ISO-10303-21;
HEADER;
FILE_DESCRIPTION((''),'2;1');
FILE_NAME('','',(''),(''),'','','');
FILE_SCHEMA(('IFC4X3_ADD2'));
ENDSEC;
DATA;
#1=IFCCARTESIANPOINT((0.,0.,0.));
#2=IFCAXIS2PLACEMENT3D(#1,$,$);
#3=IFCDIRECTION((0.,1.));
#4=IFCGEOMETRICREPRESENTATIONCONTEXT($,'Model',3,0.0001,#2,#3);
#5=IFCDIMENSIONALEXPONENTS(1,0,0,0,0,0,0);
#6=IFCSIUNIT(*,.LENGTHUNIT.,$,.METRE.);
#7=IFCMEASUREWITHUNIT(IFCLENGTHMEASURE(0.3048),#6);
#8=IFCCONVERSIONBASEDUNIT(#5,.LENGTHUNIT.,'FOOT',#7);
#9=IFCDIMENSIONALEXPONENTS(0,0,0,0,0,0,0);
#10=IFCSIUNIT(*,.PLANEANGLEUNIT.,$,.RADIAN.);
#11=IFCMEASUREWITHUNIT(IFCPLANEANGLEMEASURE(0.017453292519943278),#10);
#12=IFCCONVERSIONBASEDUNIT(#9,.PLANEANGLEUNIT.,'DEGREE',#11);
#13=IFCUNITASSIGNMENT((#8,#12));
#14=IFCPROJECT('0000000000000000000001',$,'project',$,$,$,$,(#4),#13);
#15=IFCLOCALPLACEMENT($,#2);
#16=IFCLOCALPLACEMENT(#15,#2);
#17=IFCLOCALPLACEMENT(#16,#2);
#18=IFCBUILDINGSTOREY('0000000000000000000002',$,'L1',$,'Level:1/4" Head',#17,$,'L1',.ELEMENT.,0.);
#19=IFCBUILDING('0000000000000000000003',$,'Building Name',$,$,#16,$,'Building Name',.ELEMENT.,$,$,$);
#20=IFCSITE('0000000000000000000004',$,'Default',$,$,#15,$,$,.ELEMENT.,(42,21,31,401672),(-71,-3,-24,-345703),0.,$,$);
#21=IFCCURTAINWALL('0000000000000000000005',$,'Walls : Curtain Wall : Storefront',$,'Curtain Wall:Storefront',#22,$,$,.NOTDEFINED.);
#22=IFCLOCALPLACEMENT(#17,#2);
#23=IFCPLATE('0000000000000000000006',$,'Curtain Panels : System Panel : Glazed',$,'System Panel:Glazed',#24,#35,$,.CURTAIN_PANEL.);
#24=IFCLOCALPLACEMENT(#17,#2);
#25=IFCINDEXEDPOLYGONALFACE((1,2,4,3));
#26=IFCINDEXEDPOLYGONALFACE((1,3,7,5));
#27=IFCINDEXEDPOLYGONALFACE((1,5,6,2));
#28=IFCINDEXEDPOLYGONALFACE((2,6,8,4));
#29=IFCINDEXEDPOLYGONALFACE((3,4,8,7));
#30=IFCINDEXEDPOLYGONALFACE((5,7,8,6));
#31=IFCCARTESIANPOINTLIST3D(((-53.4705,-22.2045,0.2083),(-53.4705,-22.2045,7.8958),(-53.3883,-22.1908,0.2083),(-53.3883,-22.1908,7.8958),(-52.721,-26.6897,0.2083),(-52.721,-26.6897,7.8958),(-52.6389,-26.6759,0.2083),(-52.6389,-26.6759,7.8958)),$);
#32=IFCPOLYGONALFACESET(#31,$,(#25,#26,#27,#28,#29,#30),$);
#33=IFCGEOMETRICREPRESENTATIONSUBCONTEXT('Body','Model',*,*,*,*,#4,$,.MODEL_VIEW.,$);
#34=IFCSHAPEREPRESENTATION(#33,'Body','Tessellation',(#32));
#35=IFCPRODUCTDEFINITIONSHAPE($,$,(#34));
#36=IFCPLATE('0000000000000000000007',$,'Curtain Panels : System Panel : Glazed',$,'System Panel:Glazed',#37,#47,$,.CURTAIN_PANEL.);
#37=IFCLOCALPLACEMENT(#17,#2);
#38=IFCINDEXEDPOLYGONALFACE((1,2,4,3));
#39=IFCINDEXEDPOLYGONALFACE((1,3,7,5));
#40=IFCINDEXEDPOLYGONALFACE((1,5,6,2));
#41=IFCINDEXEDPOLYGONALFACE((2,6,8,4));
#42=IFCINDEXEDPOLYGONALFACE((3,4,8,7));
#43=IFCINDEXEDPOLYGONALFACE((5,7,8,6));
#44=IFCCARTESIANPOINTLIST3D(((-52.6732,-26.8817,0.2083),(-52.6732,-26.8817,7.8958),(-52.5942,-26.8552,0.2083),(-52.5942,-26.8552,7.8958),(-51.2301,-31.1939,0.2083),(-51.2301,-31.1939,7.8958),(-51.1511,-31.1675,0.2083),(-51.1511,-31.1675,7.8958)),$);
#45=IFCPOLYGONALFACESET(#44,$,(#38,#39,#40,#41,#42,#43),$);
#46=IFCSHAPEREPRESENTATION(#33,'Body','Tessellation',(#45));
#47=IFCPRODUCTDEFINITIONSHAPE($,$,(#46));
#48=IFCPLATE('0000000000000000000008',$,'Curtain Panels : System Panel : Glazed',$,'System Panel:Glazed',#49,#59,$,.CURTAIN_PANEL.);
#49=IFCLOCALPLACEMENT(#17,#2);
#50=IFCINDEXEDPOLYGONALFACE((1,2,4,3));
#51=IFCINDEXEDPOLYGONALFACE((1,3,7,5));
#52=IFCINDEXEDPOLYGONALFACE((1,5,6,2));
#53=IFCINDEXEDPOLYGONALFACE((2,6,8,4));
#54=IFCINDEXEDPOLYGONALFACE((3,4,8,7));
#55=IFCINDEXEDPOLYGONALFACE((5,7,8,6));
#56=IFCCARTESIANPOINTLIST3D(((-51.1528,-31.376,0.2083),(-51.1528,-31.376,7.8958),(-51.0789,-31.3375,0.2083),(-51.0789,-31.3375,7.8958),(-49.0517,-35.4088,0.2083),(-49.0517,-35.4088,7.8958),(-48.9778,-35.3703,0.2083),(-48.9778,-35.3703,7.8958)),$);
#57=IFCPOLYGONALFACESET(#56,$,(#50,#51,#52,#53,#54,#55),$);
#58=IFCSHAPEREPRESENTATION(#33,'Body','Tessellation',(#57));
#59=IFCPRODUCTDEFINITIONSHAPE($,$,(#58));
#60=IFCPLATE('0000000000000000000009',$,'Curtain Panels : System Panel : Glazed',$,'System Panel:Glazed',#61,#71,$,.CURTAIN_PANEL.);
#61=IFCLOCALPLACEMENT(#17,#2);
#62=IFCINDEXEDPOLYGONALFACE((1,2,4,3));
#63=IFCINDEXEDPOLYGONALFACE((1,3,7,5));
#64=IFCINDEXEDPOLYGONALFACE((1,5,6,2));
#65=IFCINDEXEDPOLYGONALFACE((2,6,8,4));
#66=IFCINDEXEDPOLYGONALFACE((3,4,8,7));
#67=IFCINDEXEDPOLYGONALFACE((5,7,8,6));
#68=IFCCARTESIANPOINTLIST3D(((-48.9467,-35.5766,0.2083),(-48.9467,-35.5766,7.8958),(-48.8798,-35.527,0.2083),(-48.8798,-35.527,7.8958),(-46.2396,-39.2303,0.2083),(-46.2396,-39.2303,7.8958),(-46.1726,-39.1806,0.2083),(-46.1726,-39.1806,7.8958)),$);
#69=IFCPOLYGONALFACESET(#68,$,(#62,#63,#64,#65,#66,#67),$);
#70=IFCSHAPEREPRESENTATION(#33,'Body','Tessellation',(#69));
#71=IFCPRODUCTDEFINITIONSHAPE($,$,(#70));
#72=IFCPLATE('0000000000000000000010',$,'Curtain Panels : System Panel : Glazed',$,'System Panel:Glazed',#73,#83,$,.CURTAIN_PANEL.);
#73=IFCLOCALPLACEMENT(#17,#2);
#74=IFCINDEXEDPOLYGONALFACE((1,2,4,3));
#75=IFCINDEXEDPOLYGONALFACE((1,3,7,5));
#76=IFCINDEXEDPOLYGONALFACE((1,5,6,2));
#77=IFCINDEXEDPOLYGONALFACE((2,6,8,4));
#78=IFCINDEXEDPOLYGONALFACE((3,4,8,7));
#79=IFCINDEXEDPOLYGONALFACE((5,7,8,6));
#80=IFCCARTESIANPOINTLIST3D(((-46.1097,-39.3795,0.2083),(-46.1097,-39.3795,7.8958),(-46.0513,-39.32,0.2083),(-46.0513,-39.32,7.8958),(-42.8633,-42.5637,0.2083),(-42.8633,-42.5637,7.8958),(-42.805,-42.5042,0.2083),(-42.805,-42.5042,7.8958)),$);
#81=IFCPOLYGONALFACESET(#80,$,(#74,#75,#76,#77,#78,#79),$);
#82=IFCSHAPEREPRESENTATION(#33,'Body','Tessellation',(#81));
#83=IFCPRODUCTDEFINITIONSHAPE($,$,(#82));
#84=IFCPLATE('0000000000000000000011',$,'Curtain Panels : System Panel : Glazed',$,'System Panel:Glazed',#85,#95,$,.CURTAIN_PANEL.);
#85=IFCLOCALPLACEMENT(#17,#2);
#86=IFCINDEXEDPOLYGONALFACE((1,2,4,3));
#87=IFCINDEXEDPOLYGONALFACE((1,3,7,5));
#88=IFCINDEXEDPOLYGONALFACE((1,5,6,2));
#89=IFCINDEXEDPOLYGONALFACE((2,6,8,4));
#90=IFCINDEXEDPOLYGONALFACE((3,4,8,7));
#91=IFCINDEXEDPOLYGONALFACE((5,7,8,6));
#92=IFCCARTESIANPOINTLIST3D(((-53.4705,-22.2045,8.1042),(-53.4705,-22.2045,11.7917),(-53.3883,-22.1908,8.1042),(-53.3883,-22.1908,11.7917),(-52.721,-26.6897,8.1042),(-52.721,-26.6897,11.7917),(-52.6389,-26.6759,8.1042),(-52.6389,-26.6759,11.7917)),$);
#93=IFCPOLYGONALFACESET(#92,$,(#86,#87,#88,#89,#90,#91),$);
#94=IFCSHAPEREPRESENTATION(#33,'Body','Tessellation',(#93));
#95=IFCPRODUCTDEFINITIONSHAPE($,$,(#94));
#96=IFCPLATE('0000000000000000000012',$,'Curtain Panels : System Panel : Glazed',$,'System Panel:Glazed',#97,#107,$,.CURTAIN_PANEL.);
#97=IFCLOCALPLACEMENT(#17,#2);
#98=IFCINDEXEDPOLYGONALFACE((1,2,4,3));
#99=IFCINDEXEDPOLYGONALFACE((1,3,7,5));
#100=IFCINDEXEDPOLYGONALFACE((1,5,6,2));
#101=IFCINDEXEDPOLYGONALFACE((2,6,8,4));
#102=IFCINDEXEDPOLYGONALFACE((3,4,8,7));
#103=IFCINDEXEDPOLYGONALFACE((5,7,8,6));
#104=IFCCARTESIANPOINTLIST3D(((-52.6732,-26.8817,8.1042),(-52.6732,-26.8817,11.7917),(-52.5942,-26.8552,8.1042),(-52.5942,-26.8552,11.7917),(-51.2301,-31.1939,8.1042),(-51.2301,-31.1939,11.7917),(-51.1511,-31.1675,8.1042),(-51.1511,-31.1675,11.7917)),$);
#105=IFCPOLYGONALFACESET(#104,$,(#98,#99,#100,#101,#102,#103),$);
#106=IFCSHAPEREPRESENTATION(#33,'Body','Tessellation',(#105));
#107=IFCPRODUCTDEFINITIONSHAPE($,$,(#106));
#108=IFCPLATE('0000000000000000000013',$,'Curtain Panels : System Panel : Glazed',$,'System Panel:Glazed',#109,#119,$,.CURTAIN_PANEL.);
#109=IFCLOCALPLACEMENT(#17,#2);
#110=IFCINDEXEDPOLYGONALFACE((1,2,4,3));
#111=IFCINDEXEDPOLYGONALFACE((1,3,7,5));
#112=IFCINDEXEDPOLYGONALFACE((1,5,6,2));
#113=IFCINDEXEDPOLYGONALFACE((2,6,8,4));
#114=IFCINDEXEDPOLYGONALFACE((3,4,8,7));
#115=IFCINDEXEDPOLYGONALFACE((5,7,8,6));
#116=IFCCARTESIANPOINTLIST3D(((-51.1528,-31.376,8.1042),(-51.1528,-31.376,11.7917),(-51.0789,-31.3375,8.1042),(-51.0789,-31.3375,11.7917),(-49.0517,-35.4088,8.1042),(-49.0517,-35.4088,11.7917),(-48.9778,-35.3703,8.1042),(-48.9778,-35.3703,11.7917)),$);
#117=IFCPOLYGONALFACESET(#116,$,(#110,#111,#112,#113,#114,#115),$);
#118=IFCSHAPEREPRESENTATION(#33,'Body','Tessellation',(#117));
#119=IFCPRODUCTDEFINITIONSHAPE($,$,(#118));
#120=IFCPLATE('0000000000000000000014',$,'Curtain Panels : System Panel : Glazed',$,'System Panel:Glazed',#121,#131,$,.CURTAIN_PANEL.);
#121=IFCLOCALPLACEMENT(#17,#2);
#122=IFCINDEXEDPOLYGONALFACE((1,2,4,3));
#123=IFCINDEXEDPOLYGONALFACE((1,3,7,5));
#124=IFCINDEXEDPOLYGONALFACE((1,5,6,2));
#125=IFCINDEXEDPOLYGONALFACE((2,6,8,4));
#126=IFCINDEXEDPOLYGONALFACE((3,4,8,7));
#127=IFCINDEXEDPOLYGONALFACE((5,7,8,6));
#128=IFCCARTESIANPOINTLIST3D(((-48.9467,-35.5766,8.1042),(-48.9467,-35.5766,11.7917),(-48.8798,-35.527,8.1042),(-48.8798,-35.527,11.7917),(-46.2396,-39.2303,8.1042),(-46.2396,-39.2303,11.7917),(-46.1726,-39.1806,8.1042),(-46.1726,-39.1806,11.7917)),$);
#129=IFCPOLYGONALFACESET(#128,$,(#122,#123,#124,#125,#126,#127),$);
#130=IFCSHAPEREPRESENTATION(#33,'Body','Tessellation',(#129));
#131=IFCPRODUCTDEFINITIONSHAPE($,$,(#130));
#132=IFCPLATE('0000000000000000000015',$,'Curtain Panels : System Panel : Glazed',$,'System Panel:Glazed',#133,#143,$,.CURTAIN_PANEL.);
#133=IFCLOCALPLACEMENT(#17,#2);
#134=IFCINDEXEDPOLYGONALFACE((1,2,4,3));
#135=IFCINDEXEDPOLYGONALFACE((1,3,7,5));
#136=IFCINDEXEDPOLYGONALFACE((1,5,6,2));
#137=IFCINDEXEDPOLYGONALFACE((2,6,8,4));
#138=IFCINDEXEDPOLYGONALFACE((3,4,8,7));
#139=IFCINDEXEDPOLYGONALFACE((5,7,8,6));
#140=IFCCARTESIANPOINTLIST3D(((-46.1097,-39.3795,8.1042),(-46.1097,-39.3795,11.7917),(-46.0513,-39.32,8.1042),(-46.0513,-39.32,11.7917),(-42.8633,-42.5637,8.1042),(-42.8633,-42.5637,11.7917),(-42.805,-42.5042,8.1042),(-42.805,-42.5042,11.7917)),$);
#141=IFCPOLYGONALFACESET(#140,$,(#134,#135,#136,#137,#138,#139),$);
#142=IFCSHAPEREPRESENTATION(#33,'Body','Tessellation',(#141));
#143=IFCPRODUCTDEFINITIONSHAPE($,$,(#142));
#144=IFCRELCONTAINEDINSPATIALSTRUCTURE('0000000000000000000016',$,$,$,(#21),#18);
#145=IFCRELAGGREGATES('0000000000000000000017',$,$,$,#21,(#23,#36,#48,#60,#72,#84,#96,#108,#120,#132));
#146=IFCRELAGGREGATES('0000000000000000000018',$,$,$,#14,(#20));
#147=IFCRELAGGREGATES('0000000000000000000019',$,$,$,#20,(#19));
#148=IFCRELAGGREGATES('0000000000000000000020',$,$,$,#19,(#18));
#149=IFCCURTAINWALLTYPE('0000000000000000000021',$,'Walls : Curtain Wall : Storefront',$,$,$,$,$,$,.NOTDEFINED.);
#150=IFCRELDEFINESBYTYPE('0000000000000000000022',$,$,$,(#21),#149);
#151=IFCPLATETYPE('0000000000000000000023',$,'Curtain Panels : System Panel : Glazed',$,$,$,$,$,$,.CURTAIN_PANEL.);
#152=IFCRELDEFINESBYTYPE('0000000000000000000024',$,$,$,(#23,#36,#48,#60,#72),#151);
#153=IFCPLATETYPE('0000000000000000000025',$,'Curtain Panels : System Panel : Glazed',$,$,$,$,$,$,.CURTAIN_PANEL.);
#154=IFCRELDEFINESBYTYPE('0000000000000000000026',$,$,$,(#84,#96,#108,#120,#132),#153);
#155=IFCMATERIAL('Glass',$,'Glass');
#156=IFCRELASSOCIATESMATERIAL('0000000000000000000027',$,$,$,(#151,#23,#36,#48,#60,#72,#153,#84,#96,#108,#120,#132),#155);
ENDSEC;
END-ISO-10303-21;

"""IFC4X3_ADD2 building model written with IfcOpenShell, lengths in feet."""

from ifc_helpers import new_model, entity, si_unit, converted_unit, direction, frame, frame_2d, origin, place, context, subcontext, project, spatial, rectangle, extrude, source, transform, mapped, material, type_object, type_shapes, element, aggregate, save


model = new_model("IFC4X3_ADD2")

# Units and contexts
model_context = context("Model", 3, precision=0.0001, world=origin(), true_north=direction((0.0, 1.0)))
body_context = subcontext(model_context, "Body", "Model", "MODEL_VIEW")
ifc_project = project(units=[converted_unit("LENGTHUNIT", "FOOT", entity("IfcLengthMeasure", 0.3048), si_unit("LENGTHUNIT", "METRE"), dimensions=[1, 0, 0, 0, 0, 0, 0]), converted_unit("PLANEANGLEUNIT", "DEGREE", entity("IfcPlaneAngleMeasure", 0.017453292519943278), si_unit("PLANEANGLEUNIT", "RADIAN"), dimensions=[0, 0, 0, 0, 0, 0, 0])], contexts=[model_context])

# Site, building, storey
site_placement = place(None, origin())
site = spatial("IfcSite", under=ifc_project, at=site_placement, Name="Default", CompositionType="ELEMENT", RefLatitude=(42, 21, 31, 401672), RefLongitude=(-71, -3, -24, -345703), RefElevation=0.0)
building_placement = place(site_placement, origin())
building = spatial("IfcBuilding", under=site, at=building_placement, Name="Building Name", LongName="Building Name", CompositionType="ELEMENT")
storey_placement = place(building_placement, origin())
storey = spatial("IfcBuildingStorey", under=building, at=storey_placement, Name="L1", ObjectType="Level:1/4\" Head", LongName="L1", CompositionType="ELEMENT", Elevation=0.0)

# Curtain wall, plates
curtain_wall_type = type_object("IfcCurtainWallType", Name="Walls : Curtain Wall : Storefront", PredefinedType="NOTDEFINED")
curtain_wall_placement = place(storey_placement, origin())
curtain_wall = element("IfcCurtainWall", 1, at=curtain_wall_placement, inside=storey, type_object=curtain_wall_type, Name="Walls : Curtain Wall : Storefront", ObjectType="Curtain Wall:Storefront", PredefinedType="NOTDEFINED")
ifc_material_1 = material(Name="Glass", Category="Glass")
plate_type_1 = type_object("IfcPlateType", Name="Curtain Panels : System Panel : Glazed", PredefinedType="CURTAIN_PANEL", material=ifc_material_1)
shared_shape_1 = source(origin(), body_context, "Body", "SweptSolid", [
    extrude(rectangle(XDim=0.0833, YDim=4.5473, at=frame_2d((0.0, 0.0), x_axis=(1.0, 0.0))), frame((2.2737, 0.0417, 0.0), z_axis=(0.0, 0.0, 1.0), x_axis=(0.0, 1.0, 0.0)), (0.0, 0.0, 1.0), 7.6875),
])
type_shapes(plate_type_1, [shared_shape_1])
plate_1_placement = place(curtain_wall_placement, frame((-53.4705, -22.2045, 0.2083), z_axis=(0.0, 0.0, 1.0), x_axis=(0.164805, -0.986326, 0.0)))
plate_1 = element("IfcPlate", 2, at=plate_1_placement, type_object=plate_type_1, material=ifc_material_1, Name="Curtain Panels : System Panel : Glazed", ObjectType="System Panel:Glazed", PredefinedType="CURTAIN_PANEL", context=body_context, shape_type="MappedRepresentation", body=[
    mapped(shared_shape_1, transform((0.0, 0.0, 0.0), scale=1.0)),
])
plate_2_placement = place(curtain_wall_placement, frame((-52.6732, -26.8817, 0.2083), z_axis=(0.0, 0.0, 1.0), x_axis=(0.31735, -0.948308, 0.0)))
plate_2 = element("IfcPlate", 3, at=plate_2_placement, type_object=plate_type_1, material=ifc_material_1, Name="Curtain Panels : System Panel : Glazed", ObjectType="System Panel:Glazed", PredefinedType="CURTAIN_PANEL", context=body_context, shape_type="MappedRepresentation", body=[
    mapped(shared_shape_1, transform((0.0, 0.0, 0.0), scale=1.0)),
])
plate_3_placement = place(curtain_wall_placement, frame((-51.1528, -31.376, 0.2083), z_axis=(0.0, 0.0, 1.0), x_axis=(0.462051, -0.886853, 0.0)))
plate_3 = element("IfcPlate", 4, at=plate_3_placement, type_object=plate_type_1, material=ifc_material_1, Name="Curtain Panels : System Panel : Glazed", ObjectType="System Panel:Glazed", PredefinedType="CURTAIN_PANEL", context=body_context, shape_type="MappedRepresentation", body=[
    mapped(shared_shape_1, transform((0.0, 0.0, 0.0), scale=1.0)),
])
plate_4_placement = place(curtain_wall_placement, frame((-48.9467, -35.5766, 0.2083), z_axis=(0.0, 0.0, 1.0), x_axis=(0.595333, -0.803479, 0.0)))
plate_4 = element("IfcPlate", 5, at=plate_4_placement, type_object=plate_type_1, material=ifc_material_1, Name="Curtain Panels : System Panel : Glazed", ObjectType="System Panel:Glazed", PredefinedType="CURTAIN_PANEL", context=body_context, shape_type="MappedRepresentation", body=[
    mapped(shared_shape_1, transform((0.0, 0.0, 0.0), scale=1.0)),
])
plate_5_placement = place(curtain_wall_placement, frame((-46.1097, -39.3795, 0.2083), z_axis=(0.0, 0.0, 1.0), x_axis=(0.713901, -0.700247, 0.0)))
plate_5 = element("IfcPlate", 6, at=plate_5_placement, type_object=plate_type_1, material=ifc_material_1, Name="Curtain Panels : System Panel : Glazed", ObjectType="System Panel:Glazed", PredefinedType="CURTAIN_PANEL", context=body_context, shape_type="MappedRepresentation", body=[
    mapped(shared_shape_1, transform((0.0, 0.0, 0.0), scale=1.0)),
])
plate_type_2 = type_object("IfcPlateType", Name="Curtain Panels : System Panel : Glazed", PredefinedType="CURTAIN_PANEL", material=ifc_material_1)
shared_shape_2 = source(origin(), body_context, "Body", "SweptSolid", [
    extrude(rectangle(XDim=0.0833, YDim=4.5473, at=frame_2d((0.0, 0.0), x_axis=(1.0, 0.0))), frame((2.2737, 0.0417, 0.0), z_axis=(0.0, 0.0, 1.0), x_axis=(0.0, 1.0, 0.0)), (0.0, 0.0, 1.0), 3.6875),
])
type_shapes(plate_type_2, [shared_shape_2])
plate_6_placement = place(curtain_wall_placement, frame((-53.4705, -22.2045, 8.1042), z_axis=(0.0, 0.0, 1.0), x_axis=(0.164805, -0.986326, 0.0)))
plate_6 = element("IfcPlate", 7, at=plate_6_placement, type_object=plate_type_2, material=ifc_material_1, Name="Curtain Panels : System Panel : Glazed", ObjectType="System Panel:Glazed", PredefinedType="CURTAIN_PANEL", context=body_context, shape_type="MappedRepresentation", body=[
    mapped(shared_shape_2, transform((0.0, 0.0, 0.0), scale=1.0)),
])
plate_7_placement = place(curtain_wall_placement, frame((-52.6732, -26.8817, 8.1042), z_axis=(0.0, 0.0, 1.0), x_axis=(0.31735, -0.948308, 0.0)))
plate_7 = element("IfcPlate", 8, at=plate_7_placement, type_object=plate_type_2, material=ifc_material_1, Name="Curtain Panels : System Panel : Glazed", ObjectType="System Panel:Glazed", PredefinedType="CURTAIN_PANEL", context=body_context, shape_type="MappedRepresentation", body=[
    mapped(shared_shape_2, transform((0.0, 0.0, 0.0), scale=1.0)),
])
plate_8_placement = place(curtain_wall_placement, frame((-51.1528, -31.376, 8.1042), z_axis=(0.0, 0.0, 1.0), x_axis=(0.462051, -0.886853, 0.0)))
plate_8 = element("IfcPlate", 9, at=plate_8_placement, type_object=plate_type_2, material=ifc_material_1, Name="Curtain Panels : System Panel : Glazed", ObjectType="System Panel:Glazed", PredefinedType="CURTAIN_PANEL", context=body_context, shape_type="MappedRepresentation", body=[
    mapped(shared_shape_2, transform((0.0, 0.0, 0.0), scale=1.0)),
])
plate_9_placement = place(curtain_wall_placement, frame((-48.9467, -35.5766, 8.1042), z_axis=(0.0, 0.0, 1.0), x_axis=(0.595333, -0.803479, 0.0)))
plate_9 = element("IfcPlate", 10, at=plate_9_placement, type_object=plate_type_2, material=ifc_material_1, Name="Curtain Panels : System Panel : Glazed", ObjectType="System Panel:Glazed", PredefinedType="CURTAIN_PANEL", context=body_context, shape_type="MappedRepresentation", body=[
    mapped(shared_shape_2, transform((0.0, 0.0, 0.0), scale=1.0)),
])
plate_10_placement = place(curtain_wall_placement, frame((-46.1097, -39.3795, 8.1042), z_axis=(0.0, 0.0, 1.0), x_axis=(0.713901, -0.700247, 0.0)))
plate_10 = element("IfcPlate", 11, at=plate_10_placement, type_object=plate_type_2, material=ifc_material_1, Name="Curtain Panels : System Panel : Glazed", ObjectType="System Panel:Glazed", PredefinedType="CURTAIN_PANEL", context=body_context, shape_type="MappedRepresentation", body=[
    mapped(shared_shape_2, transform((0.0, 0.0, 0.0), scale=1.0)),
])
aggregate(curtain_wall, [plate_1, plate_2, plate_3, plate_4, plate_5, plate_6, plate_7, plate_8, plate_9, plate_10])

save(model, "model.ifc")
